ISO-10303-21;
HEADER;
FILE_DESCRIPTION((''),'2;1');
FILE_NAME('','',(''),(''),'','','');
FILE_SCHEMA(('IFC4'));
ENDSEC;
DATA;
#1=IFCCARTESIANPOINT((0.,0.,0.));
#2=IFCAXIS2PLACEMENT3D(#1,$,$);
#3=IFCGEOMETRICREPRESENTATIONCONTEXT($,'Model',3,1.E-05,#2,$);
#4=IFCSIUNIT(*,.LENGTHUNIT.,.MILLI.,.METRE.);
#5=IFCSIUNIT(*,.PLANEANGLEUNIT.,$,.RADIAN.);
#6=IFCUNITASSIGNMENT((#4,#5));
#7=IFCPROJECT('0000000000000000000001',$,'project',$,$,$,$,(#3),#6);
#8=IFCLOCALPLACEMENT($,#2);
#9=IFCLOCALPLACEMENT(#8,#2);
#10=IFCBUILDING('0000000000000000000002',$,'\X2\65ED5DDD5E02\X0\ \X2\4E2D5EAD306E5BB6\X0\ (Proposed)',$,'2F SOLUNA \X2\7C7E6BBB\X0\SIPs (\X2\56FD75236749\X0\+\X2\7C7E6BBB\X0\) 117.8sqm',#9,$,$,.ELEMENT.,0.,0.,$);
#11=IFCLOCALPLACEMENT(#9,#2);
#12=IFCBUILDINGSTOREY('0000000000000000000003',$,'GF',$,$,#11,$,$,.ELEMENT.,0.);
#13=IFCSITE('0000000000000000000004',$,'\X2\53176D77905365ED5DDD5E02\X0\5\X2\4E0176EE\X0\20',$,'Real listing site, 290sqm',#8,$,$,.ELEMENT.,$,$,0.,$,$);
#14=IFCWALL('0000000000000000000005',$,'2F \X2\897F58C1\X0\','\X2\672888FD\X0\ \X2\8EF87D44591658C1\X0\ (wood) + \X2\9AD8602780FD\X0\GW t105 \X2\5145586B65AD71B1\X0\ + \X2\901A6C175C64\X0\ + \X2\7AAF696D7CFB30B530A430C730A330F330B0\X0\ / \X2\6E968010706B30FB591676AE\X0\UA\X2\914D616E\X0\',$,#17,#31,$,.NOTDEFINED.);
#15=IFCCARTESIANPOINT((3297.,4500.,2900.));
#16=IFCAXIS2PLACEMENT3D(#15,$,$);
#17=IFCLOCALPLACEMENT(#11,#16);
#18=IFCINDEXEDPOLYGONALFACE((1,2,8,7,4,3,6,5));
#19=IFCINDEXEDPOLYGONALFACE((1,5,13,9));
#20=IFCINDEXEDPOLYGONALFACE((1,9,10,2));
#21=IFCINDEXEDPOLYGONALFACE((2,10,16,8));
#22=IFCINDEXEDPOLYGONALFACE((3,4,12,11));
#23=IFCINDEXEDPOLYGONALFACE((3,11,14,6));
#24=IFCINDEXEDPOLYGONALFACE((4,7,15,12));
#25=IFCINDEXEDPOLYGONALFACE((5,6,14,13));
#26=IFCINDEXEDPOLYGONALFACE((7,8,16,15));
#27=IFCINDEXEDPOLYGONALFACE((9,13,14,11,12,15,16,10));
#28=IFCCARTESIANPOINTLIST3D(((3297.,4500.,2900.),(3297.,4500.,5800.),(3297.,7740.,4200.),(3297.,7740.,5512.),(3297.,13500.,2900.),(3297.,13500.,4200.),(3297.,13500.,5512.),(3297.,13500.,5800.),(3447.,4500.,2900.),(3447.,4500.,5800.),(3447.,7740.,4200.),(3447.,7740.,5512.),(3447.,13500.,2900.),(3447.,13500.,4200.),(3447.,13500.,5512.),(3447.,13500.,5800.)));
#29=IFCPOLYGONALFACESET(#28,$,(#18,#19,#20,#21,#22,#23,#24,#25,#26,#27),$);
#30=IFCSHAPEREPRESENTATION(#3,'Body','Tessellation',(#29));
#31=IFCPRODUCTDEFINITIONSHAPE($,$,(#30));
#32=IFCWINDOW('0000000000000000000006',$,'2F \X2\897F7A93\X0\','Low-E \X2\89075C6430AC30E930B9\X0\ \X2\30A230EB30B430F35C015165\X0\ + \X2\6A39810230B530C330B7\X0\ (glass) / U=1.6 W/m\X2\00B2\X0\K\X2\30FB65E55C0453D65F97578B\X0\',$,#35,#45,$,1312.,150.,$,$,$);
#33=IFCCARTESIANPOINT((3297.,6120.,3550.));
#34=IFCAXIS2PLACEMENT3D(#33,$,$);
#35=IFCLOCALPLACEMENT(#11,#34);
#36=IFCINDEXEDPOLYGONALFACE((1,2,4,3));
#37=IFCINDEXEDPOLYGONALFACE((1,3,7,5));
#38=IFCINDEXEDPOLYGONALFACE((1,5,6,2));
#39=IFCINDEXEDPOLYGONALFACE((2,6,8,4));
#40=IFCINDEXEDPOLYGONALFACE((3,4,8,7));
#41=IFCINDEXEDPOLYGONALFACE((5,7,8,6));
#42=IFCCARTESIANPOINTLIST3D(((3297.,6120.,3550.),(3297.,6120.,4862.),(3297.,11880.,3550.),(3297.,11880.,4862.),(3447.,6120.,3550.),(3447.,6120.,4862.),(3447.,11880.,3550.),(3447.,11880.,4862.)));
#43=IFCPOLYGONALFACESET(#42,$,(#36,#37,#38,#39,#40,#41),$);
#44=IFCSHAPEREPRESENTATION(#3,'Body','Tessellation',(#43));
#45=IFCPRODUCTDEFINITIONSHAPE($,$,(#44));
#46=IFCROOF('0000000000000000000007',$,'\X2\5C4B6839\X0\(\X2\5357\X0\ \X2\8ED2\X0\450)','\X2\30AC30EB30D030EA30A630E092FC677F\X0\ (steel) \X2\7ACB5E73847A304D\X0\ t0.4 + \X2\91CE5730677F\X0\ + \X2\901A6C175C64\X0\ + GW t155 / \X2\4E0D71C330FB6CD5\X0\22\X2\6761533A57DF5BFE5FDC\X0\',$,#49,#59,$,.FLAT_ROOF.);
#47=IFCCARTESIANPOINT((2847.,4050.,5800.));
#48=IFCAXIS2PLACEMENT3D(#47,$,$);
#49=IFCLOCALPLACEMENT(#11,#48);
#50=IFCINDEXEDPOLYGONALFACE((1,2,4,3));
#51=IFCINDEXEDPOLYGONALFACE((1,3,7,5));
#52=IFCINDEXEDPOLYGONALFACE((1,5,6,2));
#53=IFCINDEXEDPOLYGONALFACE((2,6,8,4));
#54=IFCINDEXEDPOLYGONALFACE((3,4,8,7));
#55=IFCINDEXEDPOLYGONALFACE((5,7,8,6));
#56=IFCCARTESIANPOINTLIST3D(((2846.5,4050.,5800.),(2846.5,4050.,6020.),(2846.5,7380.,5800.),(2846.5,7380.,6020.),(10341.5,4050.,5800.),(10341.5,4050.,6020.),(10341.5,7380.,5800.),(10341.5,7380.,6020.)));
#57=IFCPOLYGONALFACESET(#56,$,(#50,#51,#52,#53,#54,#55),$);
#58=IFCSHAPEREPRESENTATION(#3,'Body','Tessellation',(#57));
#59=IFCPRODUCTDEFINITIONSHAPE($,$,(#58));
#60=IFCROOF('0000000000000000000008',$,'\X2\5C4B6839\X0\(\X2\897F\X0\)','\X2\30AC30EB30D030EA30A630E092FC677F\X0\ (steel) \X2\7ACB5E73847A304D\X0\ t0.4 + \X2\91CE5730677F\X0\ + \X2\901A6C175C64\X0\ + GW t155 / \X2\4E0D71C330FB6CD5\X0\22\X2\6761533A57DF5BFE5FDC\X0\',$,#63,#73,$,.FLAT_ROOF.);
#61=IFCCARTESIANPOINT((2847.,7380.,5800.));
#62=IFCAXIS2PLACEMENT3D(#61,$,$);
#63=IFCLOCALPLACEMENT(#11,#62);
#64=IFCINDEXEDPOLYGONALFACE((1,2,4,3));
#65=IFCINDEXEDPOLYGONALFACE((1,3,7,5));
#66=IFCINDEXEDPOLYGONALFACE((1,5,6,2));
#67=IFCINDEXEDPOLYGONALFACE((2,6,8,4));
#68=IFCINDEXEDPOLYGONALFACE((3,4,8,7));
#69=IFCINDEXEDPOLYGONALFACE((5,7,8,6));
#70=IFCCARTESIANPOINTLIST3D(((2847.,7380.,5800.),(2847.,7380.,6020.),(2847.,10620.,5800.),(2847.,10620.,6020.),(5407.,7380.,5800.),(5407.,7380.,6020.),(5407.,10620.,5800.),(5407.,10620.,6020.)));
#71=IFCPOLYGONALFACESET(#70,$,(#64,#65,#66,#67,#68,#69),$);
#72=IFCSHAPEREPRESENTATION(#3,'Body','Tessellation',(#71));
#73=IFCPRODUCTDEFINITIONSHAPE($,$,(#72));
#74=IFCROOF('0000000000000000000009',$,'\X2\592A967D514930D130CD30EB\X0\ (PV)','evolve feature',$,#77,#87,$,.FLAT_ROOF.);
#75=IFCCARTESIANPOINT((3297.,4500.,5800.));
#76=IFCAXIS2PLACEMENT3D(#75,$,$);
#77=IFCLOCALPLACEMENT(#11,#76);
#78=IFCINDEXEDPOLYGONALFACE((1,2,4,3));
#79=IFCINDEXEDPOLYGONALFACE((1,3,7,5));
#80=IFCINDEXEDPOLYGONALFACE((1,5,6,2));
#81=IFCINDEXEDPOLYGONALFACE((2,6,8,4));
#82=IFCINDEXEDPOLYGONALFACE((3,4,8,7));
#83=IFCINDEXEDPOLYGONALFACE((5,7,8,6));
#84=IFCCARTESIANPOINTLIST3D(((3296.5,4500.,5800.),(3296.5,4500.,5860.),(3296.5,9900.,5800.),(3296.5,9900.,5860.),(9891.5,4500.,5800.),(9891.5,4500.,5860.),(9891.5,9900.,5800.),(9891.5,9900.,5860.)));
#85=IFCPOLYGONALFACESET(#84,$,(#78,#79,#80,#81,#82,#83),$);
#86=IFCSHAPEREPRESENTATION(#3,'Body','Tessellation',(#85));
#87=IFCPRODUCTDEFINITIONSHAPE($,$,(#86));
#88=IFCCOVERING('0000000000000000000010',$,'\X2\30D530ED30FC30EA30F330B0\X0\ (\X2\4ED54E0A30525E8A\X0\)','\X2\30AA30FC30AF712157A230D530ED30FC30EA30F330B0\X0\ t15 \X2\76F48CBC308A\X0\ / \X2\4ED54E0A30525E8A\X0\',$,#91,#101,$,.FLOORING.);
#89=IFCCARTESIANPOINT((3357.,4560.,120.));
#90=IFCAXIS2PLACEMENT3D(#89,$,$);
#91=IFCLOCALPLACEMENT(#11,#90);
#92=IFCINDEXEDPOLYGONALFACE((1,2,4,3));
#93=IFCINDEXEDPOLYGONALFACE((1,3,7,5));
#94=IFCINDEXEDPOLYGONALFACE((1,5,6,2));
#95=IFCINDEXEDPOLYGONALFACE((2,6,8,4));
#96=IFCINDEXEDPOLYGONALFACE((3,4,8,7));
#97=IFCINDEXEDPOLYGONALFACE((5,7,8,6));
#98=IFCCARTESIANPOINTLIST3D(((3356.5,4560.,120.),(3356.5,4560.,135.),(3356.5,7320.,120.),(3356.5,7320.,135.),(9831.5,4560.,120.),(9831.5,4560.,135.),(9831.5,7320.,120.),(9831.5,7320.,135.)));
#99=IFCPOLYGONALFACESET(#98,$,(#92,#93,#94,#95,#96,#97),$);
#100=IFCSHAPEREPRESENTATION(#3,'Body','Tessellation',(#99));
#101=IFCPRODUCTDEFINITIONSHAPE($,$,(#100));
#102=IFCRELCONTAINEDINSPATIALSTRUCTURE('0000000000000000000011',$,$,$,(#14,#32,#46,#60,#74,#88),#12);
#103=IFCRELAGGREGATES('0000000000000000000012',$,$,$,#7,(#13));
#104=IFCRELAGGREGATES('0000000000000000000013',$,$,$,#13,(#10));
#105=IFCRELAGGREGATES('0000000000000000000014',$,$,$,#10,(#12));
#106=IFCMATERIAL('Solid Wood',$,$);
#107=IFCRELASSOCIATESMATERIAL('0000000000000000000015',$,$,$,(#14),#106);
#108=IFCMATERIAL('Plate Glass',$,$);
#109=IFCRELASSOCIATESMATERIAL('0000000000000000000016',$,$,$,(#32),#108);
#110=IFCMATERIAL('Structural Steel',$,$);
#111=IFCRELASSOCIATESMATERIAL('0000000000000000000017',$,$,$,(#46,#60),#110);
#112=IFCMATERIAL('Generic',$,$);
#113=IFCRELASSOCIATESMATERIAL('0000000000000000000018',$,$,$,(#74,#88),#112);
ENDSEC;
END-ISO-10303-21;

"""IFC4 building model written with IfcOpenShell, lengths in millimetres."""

from ifc_helpers import new_model, si_unit, frame, frame_2d, origin, place, context, project, spatial, rectangle, extrude, material, element, fill, save


model = new_model("IFC4")

# Units and contexts
model_context = context("Model", 3, precision=1e-05, world=origin())
ifc_project = project(units=[si_unit("LENGTHUNIT", "METRE", prefix="MILLI"), si_unit("PLANEANGLEUNIT", "RADIAN")], contexts=[model_context])

# Site, building, storey
site_placement = place(None, origin())
site = spatial("IfcSite", under=ifc_project, at=site_placement, Name="北海道旭川市5丁目20", ObjectType="Real listing site, 290sqm", CompositionType="ELEMENT", RefElevation=0.0)
building_placement = place(site_placement, origin())
building = spatial("IfcBuilding", under=site, at=building_placement, Name="旭川市 中庭の家 (Proposed)", ObjectType="2F SOLUNA 籾殻SIPs (国産杉+籾殻) 117.8sqm", CompositionType="ELEMENT", ElevationOfRefHeight=0.0, ElevationOfTerrain=0.0)
storey_placement = place(building_placement, origin())
storey = spatial("IfcBuildingStorey", under=building, at=storey_placement, Name="GF", CompositionType="ELEMENT", Elevation=0.0)

# Shared definitions
ifc_material_1 = material(Name="Solid Wood")
ifc_material_2 = material(Name="Generic")

# Shared definitions
ifc_material_3 = material(Name="Plate Glass")

# Wall, opening, window
wall_1_placement = place(storey_placement, frame((3297.0, 4500.0, 2900.0)))
wall_1 = element("IfcWall", 1, at=wall_1_placement, inside=storey, material=ifc_material_1, Name="2F 西壁", Description="木製 軸組外壁 (wood) + 高性能GW t105 充填断熱 + 通気層 + 窯業系サイディング / 準耐火・外皮UA配慮", PredefinedType="NOTDEFINED", context=model_context, shape_type="SweptSolid", body=[
    extrude(rectangle(XDim=150.0, YDim=9000.0, at=frame_2d((75.0, 4500.0))), frame((3297.0, 4500.0, 2900.0)), (0.0, 0.0, 1.0), 2900.0),
])
opening_1_placement = place(storey_placement, frame((3297.0, 6120.0, 3550.0)))
opening_1 = element("IfcOpeningElement", 2, at=opening_1_placement, cuts=wall_1, PredefinedType="NOTDEFINED", context=model_context, shape_type="SweptSolid", body=[
    extrude(rectangle(XDim=150.0, YDim=5760.0, at=frame_2d((75.0, 2880.0))), frame((3297.0, 6120.0, 3550.0)), (0.0, 0.0, 1.0), 1312.0),
])
window_1_placement = place(storey_placement, frame((3297.0, 6120.0, 3550.0)))
window_1 = element("IfcWindow", 3, at=window_1_placement, inside=storey, material=ifc_material_3, Name="2F 西窓", Description="Low-E 複層ガラス アルゴン封入 + 樹脂サッシ (glass) / U=1.6 W/m²K・日射取得型", OverallHeight=1312.0, OverallWidth=150.0, context=model_context, shape_type="SweptSolid", body=[
    extrude(rectangle(XDim=150.0, YDim=5760.0, at=frame_2d((75.0, 2880.0))), frame((3297.0, 6120.0, 3550.0)), (0.0, 0.0, 1.0), 1312.0),
])
fill(opening_1, window_1)

# Roofs
ifc_material_4 = material(Name="Structural Steel")
roof_1_placement = place(storey_placement, frame((2847.0, 4050.0, 5800.0)))
element("IfcRoof", 4, at=roof_1_placement, inside=storey, material=ifc_material_4, Name="屋根(南 軒450)", Description="ガルバリウム鋼板 (steel) 立平葺き t0.4 + 野地板 + 通気層 + GW t155 / 不燃・法22条区域対応", PredefinedType="FLAT_ROOF", context=model_context, shape_type="SweptSolid", body=[
    extrude(rectangle(XDim=7495.0, YDim=3330.0, at=frame_2d((3747.0, 1665.0))), frame((2847.0, 4050.0, 5800.0)), (0.0, 0.0, 1.0), 220.0),
])
roof_2_placement = place(storey_placement, frame((2847.0, 7380.0, 5800.0)))
element("IfcRoof", 5, at=roof_2_placement, inside=storey, material=ifc_material_4, Name="屋根(西)", Description="ガルバリウム鋼板 (steel) 立平葺き t0.4 + 野地板 + 通気層 + GW t155 / 不燃・法22条区域対応", PredefinedType="FLAT_ROOF", context=model_context, shape_type="SweptSolid", body=[
    extrude(rectangle(XDim=2560.0, YDim=3240.0, at=frame_2d((1280.0, 1620.0))), frame((2847.0, 7380.0, 5800.0)), (0.0, 0.0, 1.0), 220.0),
])
roof_3_placement = place(storey_placement, frame((3297.0, 4500.0, 5800.0)))
element("IfcRoof", 6, at=roof_3_placement, inside=storey, material=ifc_material_2, Name="太陽光パネル (PV)", Description="evolve feature", PredefinedType="FLAT_ROOF", context=model_context, shape_type="SweptSolid", body=[
    extrude(rectangle(XDim=6595.0, YDim=5400.0, at=frame_2d((3297.0, 2700.0))), frame((3297.0, 4500.0, 5800.0)), (0.0, 0.0, 1.0), 60.0),
])

# Covering
covering_placement = place(storey_placement, frame((3357.0, 4560.0, 120.0)))
element("IfcCovering", 7, at=covering_placement, inside=storey, material=ifc_material_2, Name="フローリング (仕上げ床)", Description="オーク無垢フローリング t15 直貼り / 仕上げ床", PredefinedType="FLOORING", context=model_context, shape_type="SweptSolid", body=[
    extrude(rectangle(XDim=6475.0, YDim=2760.0, at=frame_2d((3237.0, 1380.0))), frame((3357.0, 4560.0, 120.0)), (0.0, 0.0, 1.0), 15.0),
])

save(model, "model.ifc")
